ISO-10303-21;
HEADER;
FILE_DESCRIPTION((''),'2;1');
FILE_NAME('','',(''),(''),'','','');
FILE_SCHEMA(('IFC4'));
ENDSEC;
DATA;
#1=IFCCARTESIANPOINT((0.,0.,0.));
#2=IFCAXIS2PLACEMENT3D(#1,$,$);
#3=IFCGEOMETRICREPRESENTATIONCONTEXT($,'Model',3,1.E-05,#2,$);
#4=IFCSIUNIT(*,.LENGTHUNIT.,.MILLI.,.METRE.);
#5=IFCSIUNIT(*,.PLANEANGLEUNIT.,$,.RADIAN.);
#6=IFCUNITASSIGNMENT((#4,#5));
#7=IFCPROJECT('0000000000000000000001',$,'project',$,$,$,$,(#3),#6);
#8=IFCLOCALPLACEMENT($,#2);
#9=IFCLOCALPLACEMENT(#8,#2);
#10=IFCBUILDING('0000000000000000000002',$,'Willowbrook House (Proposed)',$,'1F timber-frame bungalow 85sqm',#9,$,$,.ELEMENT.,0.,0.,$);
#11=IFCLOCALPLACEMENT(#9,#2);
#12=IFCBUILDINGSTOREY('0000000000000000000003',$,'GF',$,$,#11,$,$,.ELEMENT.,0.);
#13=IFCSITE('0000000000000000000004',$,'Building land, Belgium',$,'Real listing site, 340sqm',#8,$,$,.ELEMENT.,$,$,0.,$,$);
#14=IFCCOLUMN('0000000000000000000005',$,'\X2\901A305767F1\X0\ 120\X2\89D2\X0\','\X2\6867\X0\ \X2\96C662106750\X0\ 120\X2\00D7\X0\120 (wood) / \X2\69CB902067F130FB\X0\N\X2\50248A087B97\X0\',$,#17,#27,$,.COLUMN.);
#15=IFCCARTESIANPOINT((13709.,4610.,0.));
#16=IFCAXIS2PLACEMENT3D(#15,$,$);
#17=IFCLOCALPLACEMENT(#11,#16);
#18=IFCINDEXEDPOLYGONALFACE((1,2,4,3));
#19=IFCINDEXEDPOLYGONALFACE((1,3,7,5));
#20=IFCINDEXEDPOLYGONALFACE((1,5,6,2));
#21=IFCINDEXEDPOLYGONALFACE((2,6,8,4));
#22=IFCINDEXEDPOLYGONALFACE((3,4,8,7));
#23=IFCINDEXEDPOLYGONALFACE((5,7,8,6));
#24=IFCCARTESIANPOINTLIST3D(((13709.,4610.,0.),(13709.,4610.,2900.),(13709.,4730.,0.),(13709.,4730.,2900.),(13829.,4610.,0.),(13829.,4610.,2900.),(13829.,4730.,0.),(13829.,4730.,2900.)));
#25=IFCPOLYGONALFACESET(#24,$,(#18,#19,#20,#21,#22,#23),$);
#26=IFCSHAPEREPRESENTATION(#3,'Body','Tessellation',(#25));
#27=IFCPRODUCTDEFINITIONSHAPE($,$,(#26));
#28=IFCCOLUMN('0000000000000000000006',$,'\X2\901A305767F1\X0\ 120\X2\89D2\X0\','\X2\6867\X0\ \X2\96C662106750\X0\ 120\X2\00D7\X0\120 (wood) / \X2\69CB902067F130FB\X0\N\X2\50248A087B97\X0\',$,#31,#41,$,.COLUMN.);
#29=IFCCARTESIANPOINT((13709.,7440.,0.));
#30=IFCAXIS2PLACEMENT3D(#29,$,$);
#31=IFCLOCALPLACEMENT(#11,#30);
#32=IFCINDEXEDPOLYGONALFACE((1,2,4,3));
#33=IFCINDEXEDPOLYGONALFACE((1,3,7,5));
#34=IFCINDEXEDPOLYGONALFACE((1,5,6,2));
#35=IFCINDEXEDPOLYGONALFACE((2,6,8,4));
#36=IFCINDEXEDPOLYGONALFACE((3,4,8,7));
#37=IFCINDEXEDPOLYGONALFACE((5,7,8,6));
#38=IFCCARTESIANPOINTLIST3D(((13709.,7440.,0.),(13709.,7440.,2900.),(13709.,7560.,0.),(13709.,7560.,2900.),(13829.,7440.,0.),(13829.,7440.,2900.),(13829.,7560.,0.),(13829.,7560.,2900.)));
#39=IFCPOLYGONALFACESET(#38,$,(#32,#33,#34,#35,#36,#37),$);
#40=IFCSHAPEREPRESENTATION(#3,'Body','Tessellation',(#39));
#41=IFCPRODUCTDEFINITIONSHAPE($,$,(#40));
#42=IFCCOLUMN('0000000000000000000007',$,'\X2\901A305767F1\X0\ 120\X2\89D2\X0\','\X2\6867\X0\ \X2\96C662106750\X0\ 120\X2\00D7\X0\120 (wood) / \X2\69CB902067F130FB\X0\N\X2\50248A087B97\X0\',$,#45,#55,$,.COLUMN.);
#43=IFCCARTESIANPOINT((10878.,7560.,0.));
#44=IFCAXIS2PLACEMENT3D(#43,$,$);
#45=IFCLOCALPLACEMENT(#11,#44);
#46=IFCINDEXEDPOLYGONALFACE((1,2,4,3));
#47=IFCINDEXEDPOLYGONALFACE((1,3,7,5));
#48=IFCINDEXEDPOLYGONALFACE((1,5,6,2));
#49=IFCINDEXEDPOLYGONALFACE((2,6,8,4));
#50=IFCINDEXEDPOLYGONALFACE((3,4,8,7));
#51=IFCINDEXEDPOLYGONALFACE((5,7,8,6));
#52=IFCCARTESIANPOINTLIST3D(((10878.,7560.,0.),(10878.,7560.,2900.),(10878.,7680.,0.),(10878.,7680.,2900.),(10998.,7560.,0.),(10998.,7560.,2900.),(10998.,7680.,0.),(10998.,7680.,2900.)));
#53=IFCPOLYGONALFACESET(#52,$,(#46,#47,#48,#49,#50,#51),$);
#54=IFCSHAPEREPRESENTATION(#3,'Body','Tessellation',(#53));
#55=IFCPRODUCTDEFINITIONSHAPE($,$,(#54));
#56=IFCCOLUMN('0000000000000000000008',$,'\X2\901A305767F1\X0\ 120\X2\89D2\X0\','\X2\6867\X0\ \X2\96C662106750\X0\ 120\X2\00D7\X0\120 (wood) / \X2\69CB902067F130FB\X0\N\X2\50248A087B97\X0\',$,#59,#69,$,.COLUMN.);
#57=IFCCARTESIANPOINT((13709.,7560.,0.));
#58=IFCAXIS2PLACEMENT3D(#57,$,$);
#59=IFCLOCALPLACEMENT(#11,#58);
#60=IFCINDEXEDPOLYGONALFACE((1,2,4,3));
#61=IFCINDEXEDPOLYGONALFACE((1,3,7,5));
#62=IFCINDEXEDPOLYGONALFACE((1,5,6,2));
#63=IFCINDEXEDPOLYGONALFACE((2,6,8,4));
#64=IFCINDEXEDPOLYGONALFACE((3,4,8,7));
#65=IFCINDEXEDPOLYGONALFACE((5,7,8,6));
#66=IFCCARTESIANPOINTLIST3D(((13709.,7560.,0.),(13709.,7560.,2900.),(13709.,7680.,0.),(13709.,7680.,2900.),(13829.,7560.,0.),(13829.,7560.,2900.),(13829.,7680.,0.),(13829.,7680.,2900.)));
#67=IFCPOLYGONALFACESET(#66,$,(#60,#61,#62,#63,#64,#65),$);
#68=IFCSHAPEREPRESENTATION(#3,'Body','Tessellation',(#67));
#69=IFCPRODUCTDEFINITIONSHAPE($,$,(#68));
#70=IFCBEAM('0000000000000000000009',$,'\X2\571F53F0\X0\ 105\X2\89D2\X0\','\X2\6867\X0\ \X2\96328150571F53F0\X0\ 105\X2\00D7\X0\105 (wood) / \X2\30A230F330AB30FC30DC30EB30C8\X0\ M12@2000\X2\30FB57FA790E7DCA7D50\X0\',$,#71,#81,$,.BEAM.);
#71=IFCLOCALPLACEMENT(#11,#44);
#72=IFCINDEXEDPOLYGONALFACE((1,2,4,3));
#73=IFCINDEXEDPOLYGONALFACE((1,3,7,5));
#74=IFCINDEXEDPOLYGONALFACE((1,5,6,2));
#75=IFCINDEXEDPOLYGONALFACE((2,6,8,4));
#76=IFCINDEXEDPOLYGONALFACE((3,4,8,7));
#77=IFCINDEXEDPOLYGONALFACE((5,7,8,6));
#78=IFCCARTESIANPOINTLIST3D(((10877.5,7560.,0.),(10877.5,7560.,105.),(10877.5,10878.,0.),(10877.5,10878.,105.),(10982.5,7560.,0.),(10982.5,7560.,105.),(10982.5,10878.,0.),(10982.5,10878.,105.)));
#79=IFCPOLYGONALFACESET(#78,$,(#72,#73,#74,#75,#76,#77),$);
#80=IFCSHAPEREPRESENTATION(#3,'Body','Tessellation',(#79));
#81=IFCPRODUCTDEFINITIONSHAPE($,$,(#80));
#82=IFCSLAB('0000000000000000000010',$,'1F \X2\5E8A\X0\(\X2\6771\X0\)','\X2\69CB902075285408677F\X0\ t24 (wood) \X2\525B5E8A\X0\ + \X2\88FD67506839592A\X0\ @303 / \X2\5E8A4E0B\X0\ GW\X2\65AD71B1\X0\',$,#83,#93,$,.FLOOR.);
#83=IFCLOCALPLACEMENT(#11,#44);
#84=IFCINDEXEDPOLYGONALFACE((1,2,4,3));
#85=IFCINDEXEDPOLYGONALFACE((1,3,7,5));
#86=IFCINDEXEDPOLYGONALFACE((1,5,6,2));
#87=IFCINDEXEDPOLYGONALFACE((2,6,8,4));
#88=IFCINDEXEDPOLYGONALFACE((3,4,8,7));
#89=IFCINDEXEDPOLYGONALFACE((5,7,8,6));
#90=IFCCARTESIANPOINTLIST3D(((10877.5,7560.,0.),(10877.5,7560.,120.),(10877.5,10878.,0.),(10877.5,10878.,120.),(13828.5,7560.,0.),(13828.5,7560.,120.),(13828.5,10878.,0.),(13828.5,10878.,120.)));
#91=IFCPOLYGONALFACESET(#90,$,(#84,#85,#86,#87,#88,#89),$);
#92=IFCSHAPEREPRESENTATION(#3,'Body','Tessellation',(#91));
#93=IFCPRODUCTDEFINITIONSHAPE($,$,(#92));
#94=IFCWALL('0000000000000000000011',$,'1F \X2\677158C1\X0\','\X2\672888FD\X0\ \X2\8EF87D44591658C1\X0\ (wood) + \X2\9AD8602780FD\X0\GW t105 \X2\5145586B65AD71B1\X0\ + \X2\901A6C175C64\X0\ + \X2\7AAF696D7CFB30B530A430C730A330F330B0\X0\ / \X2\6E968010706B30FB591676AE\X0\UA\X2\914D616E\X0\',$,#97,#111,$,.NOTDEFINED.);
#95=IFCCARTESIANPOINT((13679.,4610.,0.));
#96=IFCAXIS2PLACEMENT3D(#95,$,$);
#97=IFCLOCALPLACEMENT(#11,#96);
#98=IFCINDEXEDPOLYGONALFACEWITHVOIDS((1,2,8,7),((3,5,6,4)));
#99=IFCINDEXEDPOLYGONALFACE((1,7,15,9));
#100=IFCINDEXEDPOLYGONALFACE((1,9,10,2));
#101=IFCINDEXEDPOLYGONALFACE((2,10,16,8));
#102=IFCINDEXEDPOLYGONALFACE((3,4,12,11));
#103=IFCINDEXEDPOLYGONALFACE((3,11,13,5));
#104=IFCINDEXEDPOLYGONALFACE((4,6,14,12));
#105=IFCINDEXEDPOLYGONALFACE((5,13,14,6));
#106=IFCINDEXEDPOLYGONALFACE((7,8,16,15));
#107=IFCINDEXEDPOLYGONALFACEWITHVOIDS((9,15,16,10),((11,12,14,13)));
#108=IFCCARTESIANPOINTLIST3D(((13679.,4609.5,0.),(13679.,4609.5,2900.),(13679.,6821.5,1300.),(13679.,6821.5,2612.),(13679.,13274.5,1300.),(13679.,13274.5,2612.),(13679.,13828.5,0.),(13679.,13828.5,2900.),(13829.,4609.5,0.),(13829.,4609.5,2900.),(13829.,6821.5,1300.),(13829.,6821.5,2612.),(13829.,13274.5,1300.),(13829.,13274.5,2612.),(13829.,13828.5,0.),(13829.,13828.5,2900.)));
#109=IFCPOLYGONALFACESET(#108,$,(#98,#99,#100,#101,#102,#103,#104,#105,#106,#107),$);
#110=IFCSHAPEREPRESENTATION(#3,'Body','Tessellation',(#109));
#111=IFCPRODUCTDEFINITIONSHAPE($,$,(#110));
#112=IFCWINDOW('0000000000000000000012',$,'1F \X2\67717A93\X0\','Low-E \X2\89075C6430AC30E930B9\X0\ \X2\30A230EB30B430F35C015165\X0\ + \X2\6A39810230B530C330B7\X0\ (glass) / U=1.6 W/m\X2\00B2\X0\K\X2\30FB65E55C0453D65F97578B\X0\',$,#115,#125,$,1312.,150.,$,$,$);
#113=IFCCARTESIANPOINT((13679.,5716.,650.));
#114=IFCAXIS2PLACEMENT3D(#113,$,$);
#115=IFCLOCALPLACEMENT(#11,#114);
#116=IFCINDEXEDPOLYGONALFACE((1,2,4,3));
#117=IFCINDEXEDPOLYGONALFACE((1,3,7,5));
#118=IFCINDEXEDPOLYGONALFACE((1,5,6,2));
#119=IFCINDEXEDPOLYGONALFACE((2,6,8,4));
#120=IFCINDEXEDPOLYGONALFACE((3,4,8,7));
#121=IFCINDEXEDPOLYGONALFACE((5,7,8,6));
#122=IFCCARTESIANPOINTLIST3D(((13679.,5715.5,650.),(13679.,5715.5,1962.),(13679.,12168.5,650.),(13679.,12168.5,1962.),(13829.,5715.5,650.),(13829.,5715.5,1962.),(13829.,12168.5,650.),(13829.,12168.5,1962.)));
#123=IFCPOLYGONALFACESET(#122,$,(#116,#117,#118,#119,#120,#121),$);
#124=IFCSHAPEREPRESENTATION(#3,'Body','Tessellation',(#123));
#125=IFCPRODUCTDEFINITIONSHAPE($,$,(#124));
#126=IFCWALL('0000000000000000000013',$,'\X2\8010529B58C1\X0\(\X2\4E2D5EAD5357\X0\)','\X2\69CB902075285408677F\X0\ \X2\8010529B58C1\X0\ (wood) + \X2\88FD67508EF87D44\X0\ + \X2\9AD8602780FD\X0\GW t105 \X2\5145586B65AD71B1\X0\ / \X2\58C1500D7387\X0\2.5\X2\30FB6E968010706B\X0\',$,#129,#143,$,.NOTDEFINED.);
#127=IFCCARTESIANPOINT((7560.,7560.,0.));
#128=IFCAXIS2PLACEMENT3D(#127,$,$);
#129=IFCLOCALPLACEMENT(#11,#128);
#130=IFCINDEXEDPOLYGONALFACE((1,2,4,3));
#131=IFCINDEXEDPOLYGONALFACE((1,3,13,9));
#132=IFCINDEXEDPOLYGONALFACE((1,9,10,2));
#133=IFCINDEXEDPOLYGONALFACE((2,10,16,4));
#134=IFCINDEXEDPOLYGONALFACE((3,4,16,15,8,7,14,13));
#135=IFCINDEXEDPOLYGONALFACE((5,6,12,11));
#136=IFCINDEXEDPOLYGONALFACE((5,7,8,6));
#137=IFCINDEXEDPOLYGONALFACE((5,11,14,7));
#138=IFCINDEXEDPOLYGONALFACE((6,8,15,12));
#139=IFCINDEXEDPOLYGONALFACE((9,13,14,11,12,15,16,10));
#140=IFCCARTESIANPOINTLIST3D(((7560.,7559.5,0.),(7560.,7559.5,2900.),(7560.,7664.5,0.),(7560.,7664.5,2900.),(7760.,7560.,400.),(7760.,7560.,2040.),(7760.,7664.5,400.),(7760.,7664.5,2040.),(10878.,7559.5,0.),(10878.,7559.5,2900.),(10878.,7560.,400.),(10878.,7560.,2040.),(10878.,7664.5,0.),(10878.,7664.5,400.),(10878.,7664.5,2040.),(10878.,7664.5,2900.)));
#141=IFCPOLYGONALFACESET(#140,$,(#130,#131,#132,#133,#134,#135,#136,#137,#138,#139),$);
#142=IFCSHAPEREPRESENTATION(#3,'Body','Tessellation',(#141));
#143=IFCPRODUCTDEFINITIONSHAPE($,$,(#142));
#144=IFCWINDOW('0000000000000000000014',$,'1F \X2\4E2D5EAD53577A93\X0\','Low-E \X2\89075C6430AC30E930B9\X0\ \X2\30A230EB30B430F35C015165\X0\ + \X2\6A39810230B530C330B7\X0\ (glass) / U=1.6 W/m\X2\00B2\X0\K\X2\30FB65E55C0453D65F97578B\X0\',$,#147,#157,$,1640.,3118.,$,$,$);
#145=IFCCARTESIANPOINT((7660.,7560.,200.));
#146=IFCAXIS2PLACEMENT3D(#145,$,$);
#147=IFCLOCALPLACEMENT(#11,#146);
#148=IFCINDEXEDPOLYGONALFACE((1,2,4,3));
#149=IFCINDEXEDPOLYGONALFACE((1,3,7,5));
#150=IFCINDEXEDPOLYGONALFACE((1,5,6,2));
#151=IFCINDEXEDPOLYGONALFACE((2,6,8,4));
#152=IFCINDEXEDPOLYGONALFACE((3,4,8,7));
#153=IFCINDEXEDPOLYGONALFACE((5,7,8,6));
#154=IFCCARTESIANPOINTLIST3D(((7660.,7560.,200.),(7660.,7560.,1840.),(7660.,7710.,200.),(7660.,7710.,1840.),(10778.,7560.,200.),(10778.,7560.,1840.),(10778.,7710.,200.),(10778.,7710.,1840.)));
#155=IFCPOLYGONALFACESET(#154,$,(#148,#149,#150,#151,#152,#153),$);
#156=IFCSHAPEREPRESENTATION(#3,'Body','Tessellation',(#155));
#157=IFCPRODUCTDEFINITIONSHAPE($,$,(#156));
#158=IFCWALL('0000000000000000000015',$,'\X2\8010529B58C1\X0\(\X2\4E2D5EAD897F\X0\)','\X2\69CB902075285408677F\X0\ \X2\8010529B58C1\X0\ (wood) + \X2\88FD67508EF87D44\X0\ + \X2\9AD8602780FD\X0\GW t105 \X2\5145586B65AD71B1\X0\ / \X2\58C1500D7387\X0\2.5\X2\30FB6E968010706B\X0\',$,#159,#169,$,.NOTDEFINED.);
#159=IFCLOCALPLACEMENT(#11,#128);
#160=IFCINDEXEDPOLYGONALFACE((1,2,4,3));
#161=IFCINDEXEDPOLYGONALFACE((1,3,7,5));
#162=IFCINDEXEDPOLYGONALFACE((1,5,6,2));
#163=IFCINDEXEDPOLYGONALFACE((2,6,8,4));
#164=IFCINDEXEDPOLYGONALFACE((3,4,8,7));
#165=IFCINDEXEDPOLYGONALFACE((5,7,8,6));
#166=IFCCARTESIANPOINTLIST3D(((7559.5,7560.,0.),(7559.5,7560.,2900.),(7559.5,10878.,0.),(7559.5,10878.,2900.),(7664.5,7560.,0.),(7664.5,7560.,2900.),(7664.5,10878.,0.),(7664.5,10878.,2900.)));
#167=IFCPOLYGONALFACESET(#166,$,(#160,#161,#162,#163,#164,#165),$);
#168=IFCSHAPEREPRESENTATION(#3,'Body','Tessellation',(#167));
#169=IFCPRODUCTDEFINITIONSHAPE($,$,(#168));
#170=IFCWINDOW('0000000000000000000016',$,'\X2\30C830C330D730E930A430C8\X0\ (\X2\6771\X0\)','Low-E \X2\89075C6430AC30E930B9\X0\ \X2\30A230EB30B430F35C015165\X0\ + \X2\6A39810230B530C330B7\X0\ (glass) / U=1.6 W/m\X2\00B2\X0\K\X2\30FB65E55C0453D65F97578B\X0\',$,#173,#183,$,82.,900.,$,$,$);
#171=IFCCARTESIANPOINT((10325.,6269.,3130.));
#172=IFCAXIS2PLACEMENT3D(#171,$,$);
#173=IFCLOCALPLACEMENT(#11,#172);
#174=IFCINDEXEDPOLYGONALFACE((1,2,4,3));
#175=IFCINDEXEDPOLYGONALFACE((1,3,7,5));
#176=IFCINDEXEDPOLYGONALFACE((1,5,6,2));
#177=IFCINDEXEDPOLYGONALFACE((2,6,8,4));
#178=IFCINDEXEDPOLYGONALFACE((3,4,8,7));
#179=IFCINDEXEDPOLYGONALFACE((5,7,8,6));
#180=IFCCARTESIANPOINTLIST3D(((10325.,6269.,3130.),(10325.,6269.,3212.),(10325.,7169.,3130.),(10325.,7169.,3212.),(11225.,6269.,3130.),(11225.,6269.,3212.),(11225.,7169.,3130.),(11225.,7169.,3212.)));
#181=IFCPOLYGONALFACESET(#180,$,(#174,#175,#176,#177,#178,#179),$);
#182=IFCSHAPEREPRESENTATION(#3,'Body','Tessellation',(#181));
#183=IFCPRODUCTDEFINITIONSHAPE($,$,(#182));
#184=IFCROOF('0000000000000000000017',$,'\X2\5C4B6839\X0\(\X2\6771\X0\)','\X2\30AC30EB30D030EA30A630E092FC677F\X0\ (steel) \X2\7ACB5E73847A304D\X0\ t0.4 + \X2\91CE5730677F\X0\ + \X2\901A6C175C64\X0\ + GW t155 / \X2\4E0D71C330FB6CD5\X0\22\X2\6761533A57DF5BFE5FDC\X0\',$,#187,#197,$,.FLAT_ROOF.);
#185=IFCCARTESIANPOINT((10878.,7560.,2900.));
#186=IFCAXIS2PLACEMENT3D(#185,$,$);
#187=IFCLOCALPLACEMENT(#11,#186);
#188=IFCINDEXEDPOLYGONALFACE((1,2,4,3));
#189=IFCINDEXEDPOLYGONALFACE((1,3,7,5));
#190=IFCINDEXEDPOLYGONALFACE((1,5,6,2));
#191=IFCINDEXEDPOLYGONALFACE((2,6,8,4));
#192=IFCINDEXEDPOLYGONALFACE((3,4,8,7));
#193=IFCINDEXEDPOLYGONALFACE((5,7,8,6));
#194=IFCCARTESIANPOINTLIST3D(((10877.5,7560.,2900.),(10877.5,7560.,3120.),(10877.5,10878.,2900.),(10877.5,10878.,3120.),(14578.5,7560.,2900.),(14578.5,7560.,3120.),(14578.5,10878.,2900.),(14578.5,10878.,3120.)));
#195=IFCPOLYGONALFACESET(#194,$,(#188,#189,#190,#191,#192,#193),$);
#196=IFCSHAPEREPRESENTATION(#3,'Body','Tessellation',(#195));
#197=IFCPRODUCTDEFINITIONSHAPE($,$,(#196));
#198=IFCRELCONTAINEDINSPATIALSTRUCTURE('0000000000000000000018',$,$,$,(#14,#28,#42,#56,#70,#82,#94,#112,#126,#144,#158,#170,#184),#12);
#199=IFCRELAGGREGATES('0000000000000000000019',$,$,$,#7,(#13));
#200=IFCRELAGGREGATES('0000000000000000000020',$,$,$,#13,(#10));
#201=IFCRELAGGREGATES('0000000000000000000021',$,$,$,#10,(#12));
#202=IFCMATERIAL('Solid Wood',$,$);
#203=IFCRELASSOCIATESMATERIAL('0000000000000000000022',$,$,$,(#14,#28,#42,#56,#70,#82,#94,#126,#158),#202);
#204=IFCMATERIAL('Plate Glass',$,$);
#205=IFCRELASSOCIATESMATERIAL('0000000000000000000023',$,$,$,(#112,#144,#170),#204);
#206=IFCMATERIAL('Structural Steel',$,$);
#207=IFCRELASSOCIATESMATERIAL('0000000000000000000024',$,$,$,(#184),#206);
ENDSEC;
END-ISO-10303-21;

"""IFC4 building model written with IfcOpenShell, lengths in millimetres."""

from ifc_helpers import new_model, si_unit, frame, frame_2d, origin, place, context, project, spatial, rectangle, extrude, material, element, fill, save


model = new_model("IFC4")

# Units and contexts
model_context = context("Model", 3, precision=1e-05, world=origin())
ifc_project = project(units=[si_unit("LENGTHUNIT", "METRE", prefix="MILLI"), si_unit("PLANEANGLEUNIT", "RADIAN")], contexts=[model_context])

# Site, building, storey
site_placement = place(None, origin())
site = spatial("IfcSite", under=ifc_project, at=site_placement, Name="Building land, Belgium", ObjectType="Real listing site, 340sqm", CompositionType="ELEMENT", RefElevation=0.0)
building_placement = place(site_placement, origin())
building = spatial("IfcBuilding", under=site, at=building_placement, Name="Willowbrook House (Proposed)", ObjectType="1F timber-frame bungalow 85sqm", CompositionType="ELEMENT", ElevationOfRefHeight=0.0, ElevationOfTerrain=0.0)
storey_placement = place(building_placement, origin())
storey = spatial("IfcBuildingStorey", under=building, at=storey_placement, Name="GF", CompositionType="ELEMENT", Elevation=0.0)

# Columns
ifc_material_1 = material(Name="Solid Wood")
column_1_placement = place(storey_placement, frame((13709.0, 4610.0, 0.0)))
element("IfcColumn", 1, at=column_1_placement, inside=storey, material=ifc_material_1, Name="通し柱 120角", Description="桧 集成材 120×120 (wood) / 構造柱・N値計算", PredefinedType="COLUMN", context=model_context, shape_type="SweptSolid", body=[
    extrude(rectangle(XDim=120.0, YDim=120.0, at=frame_2d((60.0, 60.0))), frame((13709.0, 4610.0, 0.0)), (0.0, 0.0, 1.0), 2900.0),
])
column_2_placement = place(storey_placement, frame((13709.0, 7440.0, 0.0)))
element("IfcColumn", 2, at=column_2_placement, inside=storey, material=ifc_material_1, Name="通し柱 120角", Description="桧 集成材 120×120 (wood) / 構造柱・N値計算", PredefinedType="COLUMN", context=model_context, shape_type="SweptSolid", body=[
    extrude(rectangle(XDim=120.0, YDim=120.0, at=frame_2d((60.0, 60.0))), frame((13709.0, 7440.0, 0.0)), (0.0, 0.0, 1.0), 2900.0),
])
column_3_placement = place(storey_placement, frame((10878.0, 7560.0, 0.0)))
element("IfcColumn", 3, at=column_3_placement, inside=storey, material=ifc_material_1, Name="通し柱 120角", Description="桧 集成材 120×120 (wood) / 構造柱・N値計算", PredefinedType="COLUMN", context=model_context, shape_type="SweptSolid", body=[
    extrude(rectangle(XDim=120.0, YDim=120.0, at=frame_2d((60.0, 60.0))), frame((10878.0, 7560.0, 0.0)), (0.0, 0.0, 1.0), 2900.0),
])
column_4_placement = place(storey_placement, frame((13709.0, 7560.0, 0.0)))
element("IfcColumn", 4, at=column_4_placement, inside=storey, material=ifc_material_1, Name="通し柱 120角", Description="桧 集成材 120×120 (wood) / 構造柱・N値計算", PredefinedType="COLUMN", context=model_context, shape_type="SweptSolid", body=[
    extrude(rectangle(XDim=120.0, YDim=120.0, at=frame_2d((60.0, 60.0))), frame((13709.0, 7560.0, 0.0)), (0.0, 0.0, 1.0), 2900.0),
])

# Beam
beam_1_placement = place(storey_placement, frame((10878.0, 7560.0, 0.0)))
element("IfcBeam", 5, at=beam_1_placement, inside=storey, material=ifc_material_1, Name="土台 105角", Description="桧 防腐土台 105×105 (wood) / アンカーボルト M12@2000・基礎緊結", PredefinedType="BEAM", context=model_context, shape_type="SweptSolid", body=[
    extrude(rectangle(XDim=105.0, YDim=3318.0, at=frame_2d((52.0, 1659.0))), frame((10878.0, 7560.0, 0.0)), (0.0, 0.0, 1.0), 105.0),
])

# Slab
slab_placement = place(storey_placement, frame((10878.0, 7560.0, 0.0)))
element("IfcSlab", 6, at=slab_placement, inside=storey, material=ifc_material_1, Name="1F 床(東)", Description="構造用合板 t24 (wood) 剛床 + 製材根太 @303 / 床下 GW断熱", PredefinedType="FLOOR", context=model_context, shape_type="SweptSolid", body=[
    extrude(rectangle(XDim=2951.0, YDim=3318.0, at=frame_2d((1475.0, 1659.0))), frame((10878.0, 7560.0, 0.0)), (0.0, 0.0, 1.0), 120.0),
])

# Walls, openings, windows
wall_1_placement = place(storey_placement, frame((13679.0, 4610.0, 0.0)))
wall_1 = element("IfcWall", 7, at=wall_1_placement, inside=storey, material=ifc_material_1, Name="1F 東壁", Description="木製 軸組外壁 (wood) + 高性能GW t105 充填断熱 + 通気層 + 窯業系サイディング / 準耐火・外皮UA配慮", PredefinedType="NOTDEFINED", context=model_context, shape_type="SweptSolid", body=[
    extrude(rectangle(XDim=150.0, YDim=9219.0, at=frame_2d((75.0, 4609.0))), frame((13679.0, 4610.0, 0.0)), (0.0, 0.0, 1.0), 2900.0),
])
opening_1_placement = place(storey_placement, frame((13679.0, 5716.0, 650.0)))
opening_1 = element("IfcOpeningElement", 8, at=opening_1_placement, cuts=wall_1, PredefinedType="NOTDEFINED", context=model_context, shape_type="SweptSolid", body=[
    extrude(rectangle(XDim=150.0, YDim=6453.0, at=frame_2d((75.0, 3226.0))), frame((13679.0, 5716.0, 650.0)), (0.0, 0.0, 1.0), 1312.0),
])
ifc_material_2 = material(Name="Plate Glass")
window_1_placement = place(storey_placement, frame((13679.0, 5716.0, 650.0)))
window_1 = element("IfcWindow", 9, at=window_1_placement, inside=storey, material=ifc_material_2, Name="1F 東窓", Description="Low-E 複層ガラス アルゴン封入 + 樹脂サッシ (glass) / U=1.6 W/m²K・日射取得型", OverallHeight=1312.0, OverallWidth=150.0, context=model_context, shape_type="SweptSolid", body=[
    extrude(rectangle(XDim=150.0, YDim=6453.0, at=frame_2d((75.0, 3226.0))), frame((13679.0, 5716.0, 650.0)), (0.0, 0.0, 1.0), 1312.0),
])
fill(opening_1, window_1)
wall_2_placement = place(storey_placement, frame((7560.0, 7560.0, 0.0)))
wall_2 = element("IfcWall", 10, at=wall_2_placement, inside=storey, material=ifc_material_1, Name="耐力壁(中庭南)", Description="構造用合板 耐力壁 (wood) + 製材軸組 + 高性能GW t105 充填断熱 / 壁倍率2.5・準耐火", PredefinedType="NOTDEFINED", context=model_context, shape_type="SweptSolid", body=[
    extrude(rectangle(XDim=3318.0, YDim=105.0, at=frame_2d((1659.0, 52.0))), frame((7560.0, 7560.0, 0.0)), (0.0, 0.0, 1.0), 2900.0),
])
opening_2_placement = place(storey_placement, frame((7660.0, 7560.0, 200.0)))
opening_2 = element("IfcOpeningElement", 11, at=opening_2_placement, cuts=wall_2, PredefinedType="NOTDEFINED", context=model_context, shape_type="SweptSolid", body=[
    extrude(rectangle(XDim=3118.0, YDim=150.0, at=frame_2d((1559.0, 75.0))), frame((7660.0, 7560.0, 200.0)), (0.0, 0.0, 1.0), 1640.0),
])
window_2_placement = place(storey_placement, frame((7660.0, 7560.0, 200.0)))
window_2 = element("IfcWindow", 12, at=window_2_placement, inside=storey, material=ifc_material_2, Name="1F 中庭南窓", Description="Low-E 複層ガラス アルゴン封入 + 樹脂サッシ (glass) / U=1.6 W/m²K・日射取得型", OverallHeight=1640.0, OverallWidth=3118.0, context=model_context, shape_type="SweptSolid", body=[
    extrude(rectangle(XDim=3118.0, YDim=150.0, at=frame_2d((1559.0, 75.0))), frame((7660.0, 7560.0, 200.0)), (0.0, 0.0, 1.0), 1640.0),
])
fill(opening_2, window_2)

# Wall
wall_3_placement = place(storey_placement, frame((7560.0, 7560.0, 0.0)))
element("IfcWall", 13, at=wall_3_placement, inside=storey, material=ifc_material_1, Name="耐力壁(中庭西)", Description="構造用合板 耐力壁 (wood) + 製材軸組 + 高性能GW t105 充填断熱 / 壁倍率2.5・準耐火", PredefinedType="NOTDEFINED", context=model_context, shape_type="SweptSolid", body=[
    extrude(rectangle(XDim=105.0, YDim=3318.0, at=frame_2d((52.0, 1659.0))), frame((7560.0, 7560.0, 0.0)), (0.0, 0.0, 1.0), 2900.0),
])

# Window
window_3_placement = place(storey_placement, frame((10325.0, 6269.0, 3130.0)))
element("IfcWindow", 14, at=window_3_placement, inside=storey, material=ifc_material_2, Name="トップライト (東)", Description="Low-E 複層ガラス アルゴン封入 + 樹脂サッシ (glass) / U=1.6 W/m²K・日射取得型", OverallHeight=82.0, OverallWidth=900.0, context=model_context, shape_type="SweptSolid", body=[
    extrude(rectangle(XDim=900.0, YDim=900.0, at=frame_2d((450.0, 450.0))), frame((10325.0, 6269.0, 3130.0)), (0.0, 0.0, 1.0), 82.0),
])

# Roof
ifc_material_3 = material(Name="Structural Steel")
roof_placement = place(storey_placement, frame((10878.0, 7560.0, 2900.0)))
element("IfcRoof", 15, at=roof_placement, inside=storey, material=ifc_material_3, Name="屋根(東)", Description="ガルバリウム鋼板 (steel) 立平葺き t0.4 + 野地板 + 通気層 + GW t155 / 不燃・法22条区域対応", PredefinedType="FLAT_ROOF", context=model_context, shape_type="SweptSolid", body=[
    extrude(rectangle(XDim=3701.0, YDim=3318.0, at=frame_2d((1850.0, 1659.0))), frame((10878.0, 7560.0, 2900.0)), (0.0, 0.0, 1.0), 220.0),
])

save(model, "model.ifc")
